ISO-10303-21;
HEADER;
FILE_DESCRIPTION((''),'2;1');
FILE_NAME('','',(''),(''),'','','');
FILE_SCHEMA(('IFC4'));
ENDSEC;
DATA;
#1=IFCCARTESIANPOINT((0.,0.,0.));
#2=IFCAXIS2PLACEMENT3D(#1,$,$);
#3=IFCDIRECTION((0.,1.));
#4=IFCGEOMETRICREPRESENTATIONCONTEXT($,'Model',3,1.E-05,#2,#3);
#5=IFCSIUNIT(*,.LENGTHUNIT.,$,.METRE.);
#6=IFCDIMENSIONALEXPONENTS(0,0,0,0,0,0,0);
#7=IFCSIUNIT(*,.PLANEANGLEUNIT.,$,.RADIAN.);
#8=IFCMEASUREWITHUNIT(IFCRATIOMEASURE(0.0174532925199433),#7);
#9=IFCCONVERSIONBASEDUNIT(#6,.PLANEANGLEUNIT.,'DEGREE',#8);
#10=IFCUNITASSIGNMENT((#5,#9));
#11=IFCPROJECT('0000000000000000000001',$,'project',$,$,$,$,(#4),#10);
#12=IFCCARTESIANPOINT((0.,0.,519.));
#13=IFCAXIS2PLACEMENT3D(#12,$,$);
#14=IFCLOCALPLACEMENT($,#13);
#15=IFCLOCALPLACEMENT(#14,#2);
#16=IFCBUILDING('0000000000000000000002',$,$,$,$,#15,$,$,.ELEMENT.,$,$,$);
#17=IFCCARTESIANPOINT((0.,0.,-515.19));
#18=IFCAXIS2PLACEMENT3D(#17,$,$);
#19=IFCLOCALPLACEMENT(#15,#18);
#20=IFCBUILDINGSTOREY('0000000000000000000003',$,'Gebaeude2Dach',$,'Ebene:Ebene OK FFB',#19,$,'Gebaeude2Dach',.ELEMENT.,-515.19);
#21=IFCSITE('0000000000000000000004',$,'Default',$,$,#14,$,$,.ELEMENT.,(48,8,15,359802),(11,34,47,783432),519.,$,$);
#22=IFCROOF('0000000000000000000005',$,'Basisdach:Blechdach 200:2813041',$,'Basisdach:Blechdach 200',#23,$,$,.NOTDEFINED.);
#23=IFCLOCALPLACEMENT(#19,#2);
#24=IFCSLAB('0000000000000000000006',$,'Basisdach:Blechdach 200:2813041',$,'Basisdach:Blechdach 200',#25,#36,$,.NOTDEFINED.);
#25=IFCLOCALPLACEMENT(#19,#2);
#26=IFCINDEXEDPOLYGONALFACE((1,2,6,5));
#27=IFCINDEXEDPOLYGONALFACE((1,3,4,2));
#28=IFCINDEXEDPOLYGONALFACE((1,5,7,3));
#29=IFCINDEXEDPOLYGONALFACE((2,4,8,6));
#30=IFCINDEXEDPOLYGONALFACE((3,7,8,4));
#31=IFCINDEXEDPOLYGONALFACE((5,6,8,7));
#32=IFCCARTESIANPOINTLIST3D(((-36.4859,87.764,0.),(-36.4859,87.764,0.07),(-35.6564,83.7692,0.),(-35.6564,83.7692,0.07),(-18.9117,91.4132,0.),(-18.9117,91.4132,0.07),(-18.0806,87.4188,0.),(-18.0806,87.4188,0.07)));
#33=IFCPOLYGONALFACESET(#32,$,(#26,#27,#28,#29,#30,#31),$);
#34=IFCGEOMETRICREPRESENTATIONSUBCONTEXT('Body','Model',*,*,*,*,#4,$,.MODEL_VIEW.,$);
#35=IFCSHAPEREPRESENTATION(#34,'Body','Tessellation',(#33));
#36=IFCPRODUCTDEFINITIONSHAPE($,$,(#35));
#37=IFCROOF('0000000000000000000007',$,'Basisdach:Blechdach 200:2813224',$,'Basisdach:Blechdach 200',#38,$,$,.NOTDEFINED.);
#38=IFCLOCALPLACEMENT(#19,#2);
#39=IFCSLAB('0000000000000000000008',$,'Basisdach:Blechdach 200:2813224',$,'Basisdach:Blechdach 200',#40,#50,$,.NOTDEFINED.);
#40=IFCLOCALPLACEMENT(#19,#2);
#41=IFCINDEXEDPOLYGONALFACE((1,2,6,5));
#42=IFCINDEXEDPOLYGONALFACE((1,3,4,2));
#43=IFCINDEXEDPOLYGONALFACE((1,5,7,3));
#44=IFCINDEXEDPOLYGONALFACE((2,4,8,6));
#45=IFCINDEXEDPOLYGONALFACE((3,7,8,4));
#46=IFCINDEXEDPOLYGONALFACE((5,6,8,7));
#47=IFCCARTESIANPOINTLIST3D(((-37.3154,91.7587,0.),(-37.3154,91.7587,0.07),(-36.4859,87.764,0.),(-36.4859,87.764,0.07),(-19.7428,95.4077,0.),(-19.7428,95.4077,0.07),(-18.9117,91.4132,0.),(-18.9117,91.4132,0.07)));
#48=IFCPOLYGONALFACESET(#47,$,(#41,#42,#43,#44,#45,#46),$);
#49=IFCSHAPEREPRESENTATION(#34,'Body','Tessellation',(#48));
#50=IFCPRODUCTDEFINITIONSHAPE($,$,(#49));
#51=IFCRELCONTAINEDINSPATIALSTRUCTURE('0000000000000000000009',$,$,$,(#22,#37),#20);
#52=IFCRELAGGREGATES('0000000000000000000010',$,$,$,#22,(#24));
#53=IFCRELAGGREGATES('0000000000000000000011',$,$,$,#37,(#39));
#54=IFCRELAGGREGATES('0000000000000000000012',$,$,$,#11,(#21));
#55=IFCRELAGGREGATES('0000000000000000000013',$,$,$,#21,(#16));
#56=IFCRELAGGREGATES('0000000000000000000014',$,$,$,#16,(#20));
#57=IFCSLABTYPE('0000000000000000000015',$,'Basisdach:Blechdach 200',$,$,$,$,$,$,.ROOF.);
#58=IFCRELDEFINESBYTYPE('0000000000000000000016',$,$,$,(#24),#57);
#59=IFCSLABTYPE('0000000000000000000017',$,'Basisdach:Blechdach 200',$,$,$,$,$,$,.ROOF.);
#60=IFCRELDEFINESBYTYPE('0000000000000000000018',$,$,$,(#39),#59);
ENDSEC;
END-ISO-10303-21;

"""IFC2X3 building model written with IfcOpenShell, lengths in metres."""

from ifc_helpers import new_model, entity, si_unit, converted_unit, direction, frame, origin, place, context, subcontext, project, spatial, polyline, outline, extrude, type_object, element, aggregate, save


model = new_model("IFC2X3")

# Units and contexts
model_context = context("Model", 3, precision=1e-05, world=origin(), true_north=direction((0.0, 1.0)))
body_context = subcontext(model_context, "Body", "Model", "MODEL_VIEW")
ifc_project = project(units=[si_unit("LENGTHUNIT", "METRE"), converted_unit("PLANEANGLEUNIT", "DEGREE", entity("IfcRatioMeasure", 0.0174532925199433), si_unit("PLANEANGLEUNIT", "RADIAN"), dimensions=[0, 0, 0, 0, 0, 0, 0])], contexts=[model_context])

# Site, building, storey
site_placement = place(None, frame((0.0, 0.0, 519.0)))
site = spatial("IfcSite", under=ifc_project, at=site_placement, Name="Default", CompositionType="ELEMENT", RefLatitude=(48, 8, 15, 359802), RefLongitude=(11, 34, 47, 783432), RefElevation=519.0)
building_placement = place(site_placement, origin())
building = spatial("IfcBuilding", under=site, at=building_placement, CompositionType="ELEMENT")
storey_placement = place(building_placement, frame((0.0, 0.0, -515.19)))
storey = spatial("IfcBuildingStorey", under=building, at=storey_placement, Name="Gebaeude2Dach", ObjectType="Ebene:Ebene OK FFB", LongName="Gebaeude2Dach", CompositionType="ELEMENT", Elevation=-515.19)

# Roofs, slabs
roof_1_placement = place(storey_placement, frame((-36.4859, 83.7692, 0.0)))
roof_1 = element("IfcRoof", 1, at=roof_1_placement, inside=storey, Name="Basisdach:Blechdach 200:2813041", ObjectType="Basisdach:Blechdach 200", ShapeType="NOTDEFINED")
slab_type_1 = type_object("IfcSlabType", Name="Basisdach:Blechdach 200", PredefinedType="ROOF")
slab_1_placement = place(roof_1_placement, origin())
slab_1 = element("IfcSlab", 2, at=slab_1_placement, type_object=slab_type_1, Name="Basisdach:Blechdach 200:2813041", ObjectType="Basisdach:Blechdach 200", PredefinedType="NOTDEFINED", context=body_context, shape_type="SweptSolid", body=[
    extrude(outline(polyline([(9.2026, -0.1724), (8.3716, 3.822), (-9.2026, 0.1728), (-8.3731, -3.822), (9.2026, -0.1724)])), frame((9.2026, 3.822, 0.0)), (0.0, 0.0, 1.0), 0.07),
])
aggregate(roof_1, [slab_1])
roof_2_placement = place(storey_placement, frame((-37.3154, 87.764, 0.0)))
roof_2 = element("IfcRoof", 3, at=roof_2_placement, inside=storey, Name="Basisdach:Blechdach 200:2813224", ObjectType="Basisdach:Blechdach 200", ShapeType="NOTDEFINED")
slab_type_2 = type_object("IfcSlabType", Name="Basisdach:Blechdach 200", PredefinedType="ROOF")
slab_2_placement = place(roof_2_placement, origin())
slab_2 = element("IfcSlab", 4, at=slab_2_placement, type_object=slab_type_2, Name="Basisdach:Blechdach 200:2813224", ObjectType="Basisdach:Blechdach 200", PredefinedType="NOTDEFINED", context=body_context, shape_type="SweptSolid", body=[
    extrude(outline(polyline([(9.2019, -0.1726), (8.3708, 3.8219), (-9.2019, 0.1729), (-8.3723, -3.8219), (9.2019, -0.1726)])), frame((9.2019, 3.8219, 0.0)), (0.0, 0.0, 1.0), 0.07),
])
aggregate(roof_2, [slab_2])

save(model, "model.ifc")
